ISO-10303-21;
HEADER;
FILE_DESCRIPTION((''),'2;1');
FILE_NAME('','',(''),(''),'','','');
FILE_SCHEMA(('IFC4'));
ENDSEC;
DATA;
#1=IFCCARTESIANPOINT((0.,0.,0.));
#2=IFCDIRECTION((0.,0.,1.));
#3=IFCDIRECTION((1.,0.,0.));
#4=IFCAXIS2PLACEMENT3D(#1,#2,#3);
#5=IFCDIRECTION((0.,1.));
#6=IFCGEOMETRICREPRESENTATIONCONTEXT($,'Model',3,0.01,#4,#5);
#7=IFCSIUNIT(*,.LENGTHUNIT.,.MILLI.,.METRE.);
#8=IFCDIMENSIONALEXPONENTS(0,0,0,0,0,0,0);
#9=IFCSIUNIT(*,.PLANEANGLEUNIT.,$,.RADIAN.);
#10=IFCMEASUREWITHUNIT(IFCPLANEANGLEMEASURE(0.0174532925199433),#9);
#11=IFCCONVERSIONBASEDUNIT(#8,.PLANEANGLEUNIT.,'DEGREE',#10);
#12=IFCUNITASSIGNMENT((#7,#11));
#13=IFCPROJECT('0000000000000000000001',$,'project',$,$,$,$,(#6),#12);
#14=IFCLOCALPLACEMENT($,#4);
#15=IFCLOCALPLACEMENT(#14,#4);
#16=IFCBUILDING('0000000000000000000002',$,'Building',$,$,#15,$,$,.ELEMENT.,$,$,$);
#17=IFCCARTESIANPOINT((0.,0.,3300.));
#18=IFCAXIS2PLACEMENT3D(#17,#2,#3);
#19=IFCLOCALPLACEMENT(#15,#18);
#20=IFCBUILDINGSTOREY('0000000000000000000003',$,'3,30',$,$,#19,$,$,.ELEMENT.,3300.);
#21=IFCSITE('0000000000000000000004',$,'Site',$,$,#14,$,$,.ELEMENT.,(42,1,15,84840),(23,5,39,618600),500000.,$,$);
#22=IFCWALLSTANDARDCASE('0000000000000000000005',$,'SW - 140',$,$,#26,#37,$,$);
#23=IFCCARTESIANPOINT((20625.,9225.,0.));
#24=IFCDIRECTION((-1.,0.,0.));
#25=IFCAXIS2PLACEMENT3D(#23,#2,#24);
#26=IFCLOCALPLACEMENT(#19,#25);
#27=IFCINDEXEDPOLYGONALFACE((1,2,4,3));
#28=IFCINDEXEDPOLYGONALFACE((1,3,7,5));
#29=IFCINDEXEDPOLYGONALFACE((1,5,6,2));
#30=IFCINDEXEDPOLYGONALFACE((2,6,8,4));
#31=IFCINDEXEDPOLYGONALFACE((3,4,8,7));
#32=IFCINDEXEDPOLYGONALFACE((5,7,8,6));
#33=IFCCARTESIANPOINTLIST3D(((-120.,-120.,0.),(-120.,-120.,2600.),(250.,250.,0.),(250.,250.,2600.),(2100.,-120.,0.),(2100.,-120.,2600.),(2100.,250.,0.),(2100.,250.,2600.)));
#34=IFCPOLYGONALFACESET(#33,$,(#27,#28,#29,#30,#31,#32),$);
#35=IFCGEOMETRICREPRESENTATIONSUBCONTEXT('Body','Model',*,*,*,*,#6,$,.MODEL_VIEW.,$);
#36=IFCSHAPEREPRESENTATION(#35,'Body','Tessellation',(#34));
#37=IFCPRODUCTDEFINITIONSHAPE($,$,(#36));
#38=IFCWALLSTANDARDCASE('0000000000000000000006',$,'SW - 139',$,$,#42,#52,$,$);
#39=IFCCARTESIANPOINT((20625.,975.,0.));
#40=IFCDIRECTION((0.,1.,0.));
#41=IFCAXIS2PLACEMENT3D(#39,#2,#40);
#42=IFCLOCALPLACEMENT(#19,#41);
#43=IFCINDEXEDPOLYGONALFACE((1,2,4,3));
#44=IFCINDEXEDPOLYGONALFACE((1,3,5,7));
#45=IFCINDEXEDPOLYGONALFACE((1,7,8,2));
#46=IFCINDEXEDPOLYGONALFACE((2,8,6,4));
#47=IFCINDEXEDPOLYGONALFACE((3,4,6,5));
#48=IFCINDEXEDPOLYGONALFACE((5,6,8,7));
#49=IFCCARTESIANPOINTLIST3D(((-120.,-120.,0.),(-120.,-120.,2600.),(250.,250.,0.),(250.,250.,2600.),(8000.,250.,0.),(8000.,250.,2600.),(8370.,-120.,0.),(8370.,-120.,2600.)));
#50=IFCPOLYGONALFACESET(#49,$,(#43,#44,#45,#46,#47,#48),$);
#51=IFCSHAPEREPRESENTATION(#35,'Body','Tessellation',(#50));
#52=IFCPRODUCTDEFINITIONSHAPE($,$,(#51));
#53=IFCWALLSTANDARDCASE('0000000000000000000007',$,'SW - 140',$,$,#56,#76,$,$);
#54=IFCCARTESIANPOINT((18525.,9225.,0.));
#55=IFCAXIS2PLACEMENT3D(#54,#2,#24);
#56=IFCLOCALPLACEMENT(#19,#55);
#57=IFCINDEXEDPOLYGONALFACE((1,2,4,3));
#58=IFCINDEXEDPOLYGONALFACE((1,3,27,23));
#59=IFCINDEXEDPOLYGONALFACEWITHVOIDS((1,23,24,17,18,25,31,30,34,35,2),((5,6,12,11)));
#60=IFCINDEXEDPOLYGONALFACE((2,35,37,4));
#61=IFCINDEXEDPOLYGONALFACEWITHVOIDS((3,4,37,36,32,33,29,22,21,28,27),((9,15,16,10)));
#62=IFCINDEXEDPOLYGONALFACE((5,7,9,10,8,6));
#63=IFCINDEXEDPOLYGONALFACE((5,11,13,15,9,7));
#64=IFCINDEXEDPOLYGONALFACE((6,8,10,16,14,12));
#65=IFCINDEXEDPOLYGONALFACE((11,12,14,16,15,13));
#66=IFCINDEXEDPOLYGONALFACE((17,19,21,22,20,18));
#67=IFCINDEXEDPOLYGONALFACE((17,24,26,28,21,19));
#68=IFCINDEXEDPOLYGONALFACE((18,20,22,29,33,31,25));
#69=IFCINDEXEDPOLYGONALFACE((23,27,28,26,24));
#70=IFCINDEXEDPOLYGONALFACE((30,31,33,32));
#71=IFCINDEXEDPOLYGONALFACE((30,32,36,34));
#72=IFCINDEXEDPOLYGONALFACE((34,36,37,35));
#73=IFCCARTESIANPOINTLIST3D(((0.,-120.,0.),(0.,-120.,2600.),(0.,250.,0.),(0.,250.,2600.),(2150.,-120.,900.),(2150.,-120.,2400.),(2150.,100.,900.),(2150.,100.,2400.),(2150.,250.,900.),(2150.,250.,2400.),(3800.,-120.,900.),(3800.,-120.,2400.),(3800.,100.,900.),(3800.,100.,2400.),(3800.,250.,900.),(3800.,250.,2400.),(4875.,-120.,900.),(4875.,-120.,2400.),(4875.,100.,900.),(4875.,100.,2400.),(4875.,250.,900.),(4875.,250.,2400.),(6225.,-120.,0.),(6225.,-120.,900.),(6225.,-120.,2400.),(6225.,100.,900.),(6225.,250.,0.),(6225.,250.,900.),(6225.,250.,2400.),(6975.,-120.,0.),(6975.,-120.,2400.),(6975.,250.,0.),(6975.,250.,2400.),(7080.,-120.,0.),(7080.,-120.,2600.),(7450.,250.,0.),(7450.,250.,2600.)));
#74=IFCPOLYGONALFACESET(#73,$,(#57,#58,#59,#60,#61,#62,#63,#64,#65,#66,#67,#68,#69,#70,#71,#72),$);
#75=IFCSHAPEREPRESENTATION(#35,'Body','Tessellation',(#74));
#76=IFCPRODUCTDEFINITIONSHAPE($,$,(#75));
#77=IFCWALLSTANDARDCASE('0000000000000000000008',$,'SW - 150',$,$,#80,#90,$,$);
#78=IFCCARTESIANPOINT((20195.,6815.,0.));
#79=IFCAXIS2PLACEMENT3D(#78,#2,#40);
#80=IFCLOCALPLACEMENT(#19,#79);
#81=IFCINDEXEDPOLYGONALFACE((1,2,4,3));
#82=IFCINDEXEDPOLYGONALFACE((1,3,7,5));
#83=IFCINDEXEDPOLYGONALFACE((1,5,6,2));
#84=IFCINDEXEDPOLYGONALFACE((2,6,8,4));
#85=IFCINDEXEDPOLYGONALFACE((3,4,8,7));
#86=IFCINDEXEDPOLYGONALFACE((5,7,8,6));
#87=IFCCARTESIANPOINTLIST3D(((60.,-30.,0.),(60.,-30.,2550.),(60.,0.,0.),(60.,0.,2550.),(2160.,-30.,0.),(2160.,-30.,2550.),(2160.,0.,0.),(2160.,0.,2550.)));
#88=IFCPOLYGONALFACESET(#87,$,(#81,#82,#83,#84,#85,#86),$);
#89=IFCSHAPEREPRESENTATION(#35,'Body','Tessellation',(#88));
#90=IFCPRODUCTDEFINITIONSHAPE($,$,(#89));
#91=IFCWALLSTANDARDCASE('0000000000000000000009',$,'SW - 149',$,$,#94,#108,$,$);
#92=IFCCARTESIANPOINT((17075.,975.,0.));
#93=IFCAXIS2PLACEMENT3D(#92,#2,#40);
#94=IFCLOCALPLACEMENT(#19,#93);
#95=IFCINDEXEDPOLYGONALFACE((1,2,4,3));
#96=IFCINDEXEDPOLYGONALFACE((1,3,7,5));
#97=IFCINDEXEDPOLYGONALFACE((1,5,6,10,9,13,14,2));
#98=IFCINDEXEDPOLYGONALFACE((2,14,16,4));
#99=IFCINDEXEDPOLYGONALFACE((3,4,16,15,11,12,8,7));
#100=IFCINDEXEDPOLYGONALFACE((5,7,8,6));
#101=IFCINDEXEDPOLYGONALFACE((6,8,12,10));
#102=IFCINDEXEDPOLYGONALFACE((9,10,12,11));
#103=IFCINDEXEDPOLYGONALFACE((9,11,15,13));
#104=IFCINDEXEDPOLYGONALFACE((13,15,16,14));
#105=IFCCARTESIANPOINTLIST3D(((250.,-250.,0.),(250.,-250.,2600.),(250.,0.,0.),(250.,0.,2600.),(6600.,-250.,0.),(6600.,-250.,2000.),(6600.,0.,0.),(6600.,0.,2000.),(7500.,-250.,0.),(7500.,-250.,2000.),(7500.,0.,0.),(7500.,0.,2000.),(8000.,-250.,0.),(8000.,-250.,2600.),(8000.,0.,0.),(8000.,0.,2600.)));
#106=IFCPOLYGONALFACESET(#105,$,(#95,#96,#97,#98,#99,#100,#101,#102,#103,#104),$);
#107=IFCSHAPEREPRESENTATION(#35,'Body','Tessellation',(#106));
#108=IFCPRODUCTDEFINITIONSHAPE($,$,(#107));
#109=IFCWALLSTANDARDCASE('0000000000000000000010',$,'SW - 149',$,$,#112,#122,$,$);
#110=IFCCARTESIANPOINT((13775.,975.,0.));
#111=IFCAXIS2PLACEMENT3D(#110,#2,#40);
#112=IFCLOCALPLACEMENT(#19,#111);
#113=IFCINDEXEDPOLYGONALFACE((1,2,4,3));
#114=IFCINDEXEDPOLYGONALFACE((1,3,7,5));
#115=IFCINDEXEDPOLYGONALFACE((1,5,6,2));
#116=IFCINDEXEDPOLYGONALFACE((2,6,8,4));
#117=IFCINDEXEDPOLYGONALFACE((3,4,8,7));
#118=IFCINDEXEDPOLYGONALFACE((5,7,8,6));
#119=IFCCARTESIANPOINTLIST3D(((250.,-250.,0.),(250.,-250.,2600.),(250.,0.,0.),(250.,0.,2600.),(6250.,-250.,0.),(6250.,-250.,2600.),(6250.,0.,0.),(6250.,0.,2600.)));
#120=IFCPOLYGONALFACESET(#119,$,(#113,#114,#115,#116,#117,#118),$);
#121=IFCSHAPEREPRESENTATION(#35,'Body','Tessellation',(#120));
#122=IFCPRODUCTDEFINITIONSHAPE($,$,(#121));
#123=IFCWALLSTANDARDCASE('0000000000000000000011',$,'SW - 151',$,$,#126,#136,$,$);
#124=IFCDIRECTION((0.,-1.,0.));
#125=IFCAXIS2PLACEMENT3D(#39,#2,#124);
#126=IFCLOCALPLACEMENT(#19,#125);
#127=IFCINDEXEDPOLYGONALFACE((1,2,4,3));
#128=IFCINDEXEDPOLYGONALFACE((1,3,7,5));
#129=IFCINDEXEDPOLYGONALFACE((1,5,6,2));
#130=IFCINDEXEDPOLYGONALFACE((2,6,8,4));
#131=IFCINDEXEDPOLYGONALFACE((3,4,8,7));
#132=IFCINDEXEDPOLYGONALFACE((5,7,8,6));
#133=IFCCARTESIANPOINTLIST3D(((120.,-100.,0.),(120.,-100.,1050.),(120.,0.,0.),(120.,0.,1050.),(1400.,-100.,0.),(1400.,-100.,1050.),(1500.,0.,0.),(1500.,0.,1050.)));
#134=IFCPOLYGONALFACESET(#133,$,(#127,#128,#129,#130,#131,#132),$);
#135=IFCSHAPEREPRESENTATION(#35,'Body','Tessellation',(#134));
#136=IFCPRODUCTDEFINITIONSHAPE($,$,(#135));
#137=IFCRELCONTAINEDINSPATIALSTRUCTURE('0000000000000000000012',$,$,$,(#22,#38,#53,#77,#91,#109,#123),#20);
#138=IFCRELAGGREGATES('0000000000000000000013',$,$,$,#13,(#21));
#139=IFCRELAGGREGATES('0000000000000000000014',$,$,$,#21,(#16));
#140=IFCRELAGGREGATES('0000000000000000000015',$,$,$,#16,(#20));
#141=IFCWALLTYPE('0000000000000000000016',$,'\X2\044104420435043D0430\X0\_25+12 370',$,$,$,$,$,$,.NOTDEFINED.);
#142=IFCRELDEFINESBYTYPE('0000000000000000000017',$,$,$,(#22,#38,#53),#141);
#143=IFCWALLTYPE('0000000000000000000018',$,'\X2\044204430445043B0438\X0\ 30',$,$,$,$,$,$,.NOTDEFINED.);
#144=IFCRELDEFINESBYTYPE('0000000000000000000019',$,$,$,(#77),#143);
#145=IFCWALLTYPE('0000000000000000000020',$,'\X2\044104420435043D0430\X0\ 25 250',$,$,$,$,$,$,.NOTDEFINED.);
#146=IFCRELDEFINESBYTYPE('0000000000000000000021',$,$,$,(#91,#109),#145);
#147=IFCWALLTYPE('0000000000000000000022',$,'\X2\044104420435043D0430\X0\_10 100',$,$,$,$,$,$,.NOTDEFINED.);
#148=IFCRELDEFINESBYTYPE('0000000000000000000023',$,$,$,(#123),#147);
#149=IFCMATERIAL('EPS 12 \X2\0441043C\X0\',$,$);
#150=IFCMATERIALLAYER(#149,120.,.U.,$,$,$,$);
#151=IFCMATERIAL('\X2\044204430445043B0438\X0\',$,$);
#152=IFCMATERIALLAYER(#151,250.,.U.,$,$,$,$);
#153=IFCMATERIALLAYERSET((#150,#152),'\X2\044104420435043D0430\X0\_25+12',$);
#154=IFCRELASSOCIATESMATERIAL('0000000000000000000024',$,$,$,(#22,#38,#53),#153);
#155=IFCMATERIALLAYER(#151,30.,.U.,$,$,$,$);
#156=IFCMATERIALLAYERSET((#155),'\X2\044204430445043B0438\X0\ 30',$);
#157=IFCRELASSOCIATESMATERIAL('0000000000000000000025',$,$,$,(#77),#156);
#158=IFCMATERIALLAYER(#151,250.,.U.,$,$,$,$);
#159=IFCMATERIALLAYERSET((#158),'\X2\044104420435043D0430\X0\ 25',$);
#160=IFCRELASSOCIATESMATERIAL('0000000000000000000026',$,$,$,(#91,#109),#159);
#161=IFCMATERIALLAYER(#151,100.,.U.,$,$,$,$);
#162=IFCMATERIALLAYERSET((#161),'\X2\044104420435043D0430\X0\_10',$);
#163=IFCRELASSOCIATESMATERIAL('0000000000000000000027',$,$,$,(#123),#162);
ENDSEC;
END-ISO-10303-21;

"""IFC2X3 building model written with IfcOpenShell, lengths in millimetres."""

from ifc_helpers import new_model, entity, si_unit, converted_unit, direction, frame, origin_with_axes, origin_2d_with_axis, place, context, subcontext, project, spatial, polyline, rectangle, outline, extrude, material, layer, layer_set, layer_usage, type_object, element, save


model = new_model("IFC2X3")

# Units and contexts
model_context = context("Model", 3, precision=0.01, world=origin_with_axes(), true_north=direction((0.0, 1.0)))
body_context = subcontext(model_context, "Body", "Model", "MODEL_VIEW")
ifc_project = project(units=[si_unit("LENGTHUNIT", "METRE", prefix="MILLI"), converted_unit("PLANEANGLEUNIT", "DEGREE", entity("IfcPlaneAngleMeasure", 0.0174532925199433), si_unit("PLANEANGLEUNIT", "RADIAN"), dimensions=[0, 0, 0, 0, 0, 0, 0])], contexts=[model_context])

# Site, building, storey
site_placement = place(None, origin_with_axes())
site = spatial("IfcSite", under=ifc_project, at=site_placement, Name="Site", CompositionType="ELEMENT", RefLatitude=(42, 1, 15, 84840), RefLongitude=(23, 5, 39, 618600), RefElevation=500000.0)
building_placement = place(site_placement, origin_with_axes())
building = spatial("IfcBuilding", under=site, at=building_placement, Name="Building", CompositionType="ELEMENT")
storey_placement = place(building_placement, frame((0.0, 0.0, 3300.0), z_axis=(0.0, 0.0, 1.0), x_axis=(1.0, 0.0, 0.0)))
storey = spatial("IfcBuildingStorey", under=building, at=storey_placement, Name="3,30", CompositionType="ELEMENT", Elevation=3300.0)

# Walls
ifc_material_1 = material(Name="EPS 12 см")
ifc_layer_1 = layer(ifc_material_1, 120.0, ventilated="UNKNOWN")
ifc_material_2 = material(Name="тухли")
ifc_layer_2 = layer(ifc_material_2, 250.0, ventilated="UNKNOWN")
ifc_layer_set_1 = layer_set([ifc_layer_1, ifc_layer_2], Name="стена_25+12")
ifc_layer_usage_1 = layer_usage(ifc_layer_set_1, "AXIS2", "POSITIVE", -120.0)
wall_type_1 = type_object("IfcWallType", Name="стена_25+12 370", PredefinedType="NOTDEFINED")
wall_1_placement = place(storey_placement, frame((20625.0, 9225.0, 0.0), z_axis=(0.0, 0.0, 1.0), x_axis=(-1.0, 0.0, 0.0)))
element("IfcWallStandardCase", 1, at=wall_1_placement, inside=storey, type_object=wall_type_1, material=ifc_layer_usage_1, Name="SW - 140", context=body_context, shape_type="SweptSolid", body=[
    extrude(outline(polyline([(-120.0, -120.0), (2100.0, -120.0), (2100.0, 250.0), (250.0, 250.0), (-120.0, -120.0)])), origin_with_axes(), (0.0, 0.0, 1.0), 2600.0),
])
ifc_layer_usage_2 = layer_usage(ifc_layer_set_1, "AXIS2", "POSITIVE", -120.0)
wall_2_placement = place(storey_placement, frame((20625.0, 975.0, 0.0), z_axis=(0.0, 0.0, 1.0), x_axis=(0.0, 1.0, 0.0)))
element("IfcWallStandardCase", 2, at=wall_2_placement, inside=storey, type_object=wall_type_1, material=ifc_layer_usage_2, Name="SW - 139", context=body_context, shape_type="SweptSolid", body=[
    extrude(outline(polyline([(-120.0, -120.0), (8370.0, -120.0), (8000.0, 250.0), (250.0, 250.0), (-120.0, -120.0)])), origin_with_axes(), (0.0, 0.0, 1.0), 2600.0),
])

# Wall, openings
ifc_layer_usage_3 = layer_usage(ifc_layer_set_1, "AXIS2", "POSITIVE", -120.0)
wall_3_placement = place(storey_placement, frame((18525.0, 9225.0, 0.0), z_axis=(0.0, 0.0, 1.0), x_axis=(-1.0, 0.0, 0.0)))
wall_3 = element("IfcWallStandardCase", 3, at=wall_3_placement, inside=storey, type_object=wall_type_1, material=ifc_layer_usage_3, Name="SW - 140", context=body_context, shape_type="SweptSolid", body=[
    extrude(outline(polyline([(0.0, -120.0), (7080.0, -120.0), (7450.0, 250.0), (0.0, 250.0), (0.0, -120.0)])), origin_with_axes(), (0.0, 0.0, 1.0), 2600.0),
])
opening_1_placement = place(wall_3_placement, frame((5550.0, 0.0, 900.0), z_axis=(0.0, 0.0, 1.0), x_axis=(1.0, 0.0, 0.0)))
element("IfcOpeningElement", 4, at=opening_1_placement, cuts=wall_3, context=body_context, shape_type="SweptSolid", body=[
    extrude(rectangle(XDim=1350.0, YDim=1500.0, at=origin_2d_with_axis()), frame((0.0, 100.0, 750.0), z_axis=(0.0, -1.0, 0.0), x_axis=(-1.0, 0.0, 0.0)), (0.0, 0.0, 1.0), 590.0),
    extrude(rectangle(XDim=1350.0, YDim=1500.0, at=origin_2d_with_axis()), frame((0.0, 100.0, 750.0), z_axis=(0.0, 1.0, 0.0), x_axis=(-1.0, 0.0, 0.0)), (0.0, 0.0, 1.0), 520.0),
])
opening_2_placement = place(wall_3_placement, frame((6600.0, 0.0, 0.0), z_axis=(0.0, 0.0, 1.0), x_axis=(1.0, 0.0, 0.0)))
element("IfcOpeningElement", 5, at=opening_2_placement, cuts=wall_3, context=body_context, shape_type="SweptSolid", body=[
    extrude(rectangle(XDim=750.0, YDim=2400.0, at=origin_2d_with_axis()), frame((0.0, 370.0, 1200.0), z_axis=(0.0, -1.0, 0.0), x_axis=(1.0, 0.0, 0.0)), (0.0, 0.0, 1.0), 1110.0),
])
opening_3_placement = place(wall_3_placement, frame((2975.0, 0.0, 900.0), z_axis=(0.0, 0.0, 1.0), x_axis=(1.0, 0.0, 0.0)))
element("IfcOpeningElement", 6, at=opening_3_placement, cuts=wall_3, context=body_context, shape_type="SweptSolid", body=[
    extrude(rectangle(XDim=1650.0, YDim=1500.0, at=origin_2d_with_axis()), frame((0.0, 100.0, 750.0), z_axis=(0.0, -1.0, 0.0), x_axis=(-1.0, 0.0, 0.0)), (0.0, 0.0, 1.0), 590.0),
    extrude(rectangle(XDim=1650.0, YDim=1500.0, at=origin_2d_with_axis()), frame((0.0, 100.0, 750.0), z_axis=(0.0, 1.0, 0.0), x_axis=(-1.0, 0.0, 0.0)), (0.0, 0.0, 1.0), 520.0),
])

# Wall
ifc_layer_3 = layer(ifc_material_2, 30.0, ventilated="UNKNOWN")
ifc_layer_set_2 = layer_set([ifc_layer_3], Name="тухли 30")
ifc_layer_usage_4 = layer_usage(ifc_layer_set_2, "AXIS2", "NEGATIVE", 0.0)
wall_type_2 = type_object("IfcWallType", Name="тухли 30", PredefinedType="NOTDEFINED")
wall_4_placement = place(storey_placement, frame((20195.0, 6815.0, 0.0), z_axis=(0.0, 0.0, 1.0), x_axis=(0.0, 1.0, 0.0)))
element("IfcWallStandardCase", 7, at=wall_4_placement, inside=storey, type_object=wall_type_2, material=ifc_layer_usage_4, Name="SW - 150", context=body_context, shape_type="SweptSolid", body=[
    extrude(outline(polyline([(60.0, -30.0), (2160.0, -30.0), (2160.0, 0.0), (60.0, 0.0), (60.0, -30.0)])), origin_with_axes(), (0.0, 0.0, 1.0), 2550.0),
])

# Wall, opening
ifc_layer_4 = layer(ifc_material_2, 250.0, ventilated="UNKNOWN")
ifc_layer_set_3 = layer_set([ifc_layer_4], Name="стена 25")
ifc_layer_usage_5 = layer_usage(ifc_layer_set_3, "AXIS2", "NEGATIVE", 0.0)
wall_type_3 = type_object("IfcWallType", Name="стена 25 250", PredefinedType="NOTDEFINED")
wall_5_placement = place(storey_placement, frame((17075.0, 975.0, 0.0), z_axis=(0.0, 0.0, 1.0), x_axis=(0.0, 1.0, 0.0)))
wall_5 = element("IfcWallStandardCase", 8, at=wall_5_placement, inside=storey, type_object=wall_type_3, material=ifc_layer_usage_5, Name="SW - 149", context=body_context, shape_type="SweptSolid", body=[
    extrude(outline(polyline([(250.0, -250.0), (8000.0, -250.0), (8000.0, 0.0), (250.0, 0.0), (250.0, -250.0)])), origin_with_axes(), (0.0, 0.0, 1.0), 2600.0),
])
opening_4_placement = place(wall_5_placement, frame((7050.0, 0.0, 0.0), z_axis=(0.0, 0.0, 1.0), x_axis=(1.0, 0.0, 0.0)))
element("IfcOpeningElement", 9, at=opening_4_placement, cuts=wall_5, context=body_context, shape_type="SweptSolid", body=[
    extrude(rectangle(XDim=900.0, YDim=2000.0, at=origin_2d_with_axis()), frame((0.0, 250.0, 1000.0), z_axis=(0.0, 1.0, 0.0), x_axis=(1.0, 0.0, 0.0)), (0.0, 0.0, -1.0), 750.0),
])

# Wall
ifc_layer_usage_6 = layer_usage(ifc_layer_set_3, "AXIS2", "NEGATIVE", 0.0)
wall_6_placement = place(storey_placement, frame((13775.0, 975.0, 0.0), z_axis=(0.0, 0.0, 1.0), x_axis=(0.0, 1.0, 0.0)))
element("IfcWallStandardCase", 10, at=wall_6_placement, inside=storey, type_object=wall_type_3, material=ifc_layer_usage_6, Name="SW - 149", context=body_context, shape_type="SweptSolid", body=[
    extrude(outline(polyline([(250.0, -250.0), (6250.0, -250.0), (6250.0, 0.0), (250.0, 0.0), (250.0, -250.0)])), origin_with_axes(), (0.0, 0.0, 1.0), 2600.0),
])

# Wall
ifc_layer_5 = layer(ifc_material_2, 100.0, ventilated="UNKNOWN")
ifc_layer_set_4 = layer_set([ifc_layer_5], Name="стена_10")
wall_type_4 = type_object("IfcWallType", Name="стена_10 100", PredefinedType="NOTDEFINED")
ifc_layer_usage_7 = layer_usage(ifc_layer_set_4, "AXIS2", "NEGATIVE", 0.0)
wall_7_placement = place(storey_placement, frame((20625.0, 975.0, 0.0), z_axis=(0.0, 0.0, 1.0), x_axis=(0.0, -1.0, 0.0)))
element("IfcWallStandardCase", 11, at=wall_7_placement, inside=storey, type_object=wall_type_4, material=ifc_layer_usage_7, Name="SW - 151", context=body_context, shape_type="SweptSolid", body=[
    extrude(outline(polyline([(120.0, -100.0), (1400.0, -100.0), (1500.0, 0.0), (120.0, 0.0), (120.0, -100.0)])), origin_with_axes(), (0.0, 0.0, 1.0), 1050.0),
])

save(model, "model.ifc")
